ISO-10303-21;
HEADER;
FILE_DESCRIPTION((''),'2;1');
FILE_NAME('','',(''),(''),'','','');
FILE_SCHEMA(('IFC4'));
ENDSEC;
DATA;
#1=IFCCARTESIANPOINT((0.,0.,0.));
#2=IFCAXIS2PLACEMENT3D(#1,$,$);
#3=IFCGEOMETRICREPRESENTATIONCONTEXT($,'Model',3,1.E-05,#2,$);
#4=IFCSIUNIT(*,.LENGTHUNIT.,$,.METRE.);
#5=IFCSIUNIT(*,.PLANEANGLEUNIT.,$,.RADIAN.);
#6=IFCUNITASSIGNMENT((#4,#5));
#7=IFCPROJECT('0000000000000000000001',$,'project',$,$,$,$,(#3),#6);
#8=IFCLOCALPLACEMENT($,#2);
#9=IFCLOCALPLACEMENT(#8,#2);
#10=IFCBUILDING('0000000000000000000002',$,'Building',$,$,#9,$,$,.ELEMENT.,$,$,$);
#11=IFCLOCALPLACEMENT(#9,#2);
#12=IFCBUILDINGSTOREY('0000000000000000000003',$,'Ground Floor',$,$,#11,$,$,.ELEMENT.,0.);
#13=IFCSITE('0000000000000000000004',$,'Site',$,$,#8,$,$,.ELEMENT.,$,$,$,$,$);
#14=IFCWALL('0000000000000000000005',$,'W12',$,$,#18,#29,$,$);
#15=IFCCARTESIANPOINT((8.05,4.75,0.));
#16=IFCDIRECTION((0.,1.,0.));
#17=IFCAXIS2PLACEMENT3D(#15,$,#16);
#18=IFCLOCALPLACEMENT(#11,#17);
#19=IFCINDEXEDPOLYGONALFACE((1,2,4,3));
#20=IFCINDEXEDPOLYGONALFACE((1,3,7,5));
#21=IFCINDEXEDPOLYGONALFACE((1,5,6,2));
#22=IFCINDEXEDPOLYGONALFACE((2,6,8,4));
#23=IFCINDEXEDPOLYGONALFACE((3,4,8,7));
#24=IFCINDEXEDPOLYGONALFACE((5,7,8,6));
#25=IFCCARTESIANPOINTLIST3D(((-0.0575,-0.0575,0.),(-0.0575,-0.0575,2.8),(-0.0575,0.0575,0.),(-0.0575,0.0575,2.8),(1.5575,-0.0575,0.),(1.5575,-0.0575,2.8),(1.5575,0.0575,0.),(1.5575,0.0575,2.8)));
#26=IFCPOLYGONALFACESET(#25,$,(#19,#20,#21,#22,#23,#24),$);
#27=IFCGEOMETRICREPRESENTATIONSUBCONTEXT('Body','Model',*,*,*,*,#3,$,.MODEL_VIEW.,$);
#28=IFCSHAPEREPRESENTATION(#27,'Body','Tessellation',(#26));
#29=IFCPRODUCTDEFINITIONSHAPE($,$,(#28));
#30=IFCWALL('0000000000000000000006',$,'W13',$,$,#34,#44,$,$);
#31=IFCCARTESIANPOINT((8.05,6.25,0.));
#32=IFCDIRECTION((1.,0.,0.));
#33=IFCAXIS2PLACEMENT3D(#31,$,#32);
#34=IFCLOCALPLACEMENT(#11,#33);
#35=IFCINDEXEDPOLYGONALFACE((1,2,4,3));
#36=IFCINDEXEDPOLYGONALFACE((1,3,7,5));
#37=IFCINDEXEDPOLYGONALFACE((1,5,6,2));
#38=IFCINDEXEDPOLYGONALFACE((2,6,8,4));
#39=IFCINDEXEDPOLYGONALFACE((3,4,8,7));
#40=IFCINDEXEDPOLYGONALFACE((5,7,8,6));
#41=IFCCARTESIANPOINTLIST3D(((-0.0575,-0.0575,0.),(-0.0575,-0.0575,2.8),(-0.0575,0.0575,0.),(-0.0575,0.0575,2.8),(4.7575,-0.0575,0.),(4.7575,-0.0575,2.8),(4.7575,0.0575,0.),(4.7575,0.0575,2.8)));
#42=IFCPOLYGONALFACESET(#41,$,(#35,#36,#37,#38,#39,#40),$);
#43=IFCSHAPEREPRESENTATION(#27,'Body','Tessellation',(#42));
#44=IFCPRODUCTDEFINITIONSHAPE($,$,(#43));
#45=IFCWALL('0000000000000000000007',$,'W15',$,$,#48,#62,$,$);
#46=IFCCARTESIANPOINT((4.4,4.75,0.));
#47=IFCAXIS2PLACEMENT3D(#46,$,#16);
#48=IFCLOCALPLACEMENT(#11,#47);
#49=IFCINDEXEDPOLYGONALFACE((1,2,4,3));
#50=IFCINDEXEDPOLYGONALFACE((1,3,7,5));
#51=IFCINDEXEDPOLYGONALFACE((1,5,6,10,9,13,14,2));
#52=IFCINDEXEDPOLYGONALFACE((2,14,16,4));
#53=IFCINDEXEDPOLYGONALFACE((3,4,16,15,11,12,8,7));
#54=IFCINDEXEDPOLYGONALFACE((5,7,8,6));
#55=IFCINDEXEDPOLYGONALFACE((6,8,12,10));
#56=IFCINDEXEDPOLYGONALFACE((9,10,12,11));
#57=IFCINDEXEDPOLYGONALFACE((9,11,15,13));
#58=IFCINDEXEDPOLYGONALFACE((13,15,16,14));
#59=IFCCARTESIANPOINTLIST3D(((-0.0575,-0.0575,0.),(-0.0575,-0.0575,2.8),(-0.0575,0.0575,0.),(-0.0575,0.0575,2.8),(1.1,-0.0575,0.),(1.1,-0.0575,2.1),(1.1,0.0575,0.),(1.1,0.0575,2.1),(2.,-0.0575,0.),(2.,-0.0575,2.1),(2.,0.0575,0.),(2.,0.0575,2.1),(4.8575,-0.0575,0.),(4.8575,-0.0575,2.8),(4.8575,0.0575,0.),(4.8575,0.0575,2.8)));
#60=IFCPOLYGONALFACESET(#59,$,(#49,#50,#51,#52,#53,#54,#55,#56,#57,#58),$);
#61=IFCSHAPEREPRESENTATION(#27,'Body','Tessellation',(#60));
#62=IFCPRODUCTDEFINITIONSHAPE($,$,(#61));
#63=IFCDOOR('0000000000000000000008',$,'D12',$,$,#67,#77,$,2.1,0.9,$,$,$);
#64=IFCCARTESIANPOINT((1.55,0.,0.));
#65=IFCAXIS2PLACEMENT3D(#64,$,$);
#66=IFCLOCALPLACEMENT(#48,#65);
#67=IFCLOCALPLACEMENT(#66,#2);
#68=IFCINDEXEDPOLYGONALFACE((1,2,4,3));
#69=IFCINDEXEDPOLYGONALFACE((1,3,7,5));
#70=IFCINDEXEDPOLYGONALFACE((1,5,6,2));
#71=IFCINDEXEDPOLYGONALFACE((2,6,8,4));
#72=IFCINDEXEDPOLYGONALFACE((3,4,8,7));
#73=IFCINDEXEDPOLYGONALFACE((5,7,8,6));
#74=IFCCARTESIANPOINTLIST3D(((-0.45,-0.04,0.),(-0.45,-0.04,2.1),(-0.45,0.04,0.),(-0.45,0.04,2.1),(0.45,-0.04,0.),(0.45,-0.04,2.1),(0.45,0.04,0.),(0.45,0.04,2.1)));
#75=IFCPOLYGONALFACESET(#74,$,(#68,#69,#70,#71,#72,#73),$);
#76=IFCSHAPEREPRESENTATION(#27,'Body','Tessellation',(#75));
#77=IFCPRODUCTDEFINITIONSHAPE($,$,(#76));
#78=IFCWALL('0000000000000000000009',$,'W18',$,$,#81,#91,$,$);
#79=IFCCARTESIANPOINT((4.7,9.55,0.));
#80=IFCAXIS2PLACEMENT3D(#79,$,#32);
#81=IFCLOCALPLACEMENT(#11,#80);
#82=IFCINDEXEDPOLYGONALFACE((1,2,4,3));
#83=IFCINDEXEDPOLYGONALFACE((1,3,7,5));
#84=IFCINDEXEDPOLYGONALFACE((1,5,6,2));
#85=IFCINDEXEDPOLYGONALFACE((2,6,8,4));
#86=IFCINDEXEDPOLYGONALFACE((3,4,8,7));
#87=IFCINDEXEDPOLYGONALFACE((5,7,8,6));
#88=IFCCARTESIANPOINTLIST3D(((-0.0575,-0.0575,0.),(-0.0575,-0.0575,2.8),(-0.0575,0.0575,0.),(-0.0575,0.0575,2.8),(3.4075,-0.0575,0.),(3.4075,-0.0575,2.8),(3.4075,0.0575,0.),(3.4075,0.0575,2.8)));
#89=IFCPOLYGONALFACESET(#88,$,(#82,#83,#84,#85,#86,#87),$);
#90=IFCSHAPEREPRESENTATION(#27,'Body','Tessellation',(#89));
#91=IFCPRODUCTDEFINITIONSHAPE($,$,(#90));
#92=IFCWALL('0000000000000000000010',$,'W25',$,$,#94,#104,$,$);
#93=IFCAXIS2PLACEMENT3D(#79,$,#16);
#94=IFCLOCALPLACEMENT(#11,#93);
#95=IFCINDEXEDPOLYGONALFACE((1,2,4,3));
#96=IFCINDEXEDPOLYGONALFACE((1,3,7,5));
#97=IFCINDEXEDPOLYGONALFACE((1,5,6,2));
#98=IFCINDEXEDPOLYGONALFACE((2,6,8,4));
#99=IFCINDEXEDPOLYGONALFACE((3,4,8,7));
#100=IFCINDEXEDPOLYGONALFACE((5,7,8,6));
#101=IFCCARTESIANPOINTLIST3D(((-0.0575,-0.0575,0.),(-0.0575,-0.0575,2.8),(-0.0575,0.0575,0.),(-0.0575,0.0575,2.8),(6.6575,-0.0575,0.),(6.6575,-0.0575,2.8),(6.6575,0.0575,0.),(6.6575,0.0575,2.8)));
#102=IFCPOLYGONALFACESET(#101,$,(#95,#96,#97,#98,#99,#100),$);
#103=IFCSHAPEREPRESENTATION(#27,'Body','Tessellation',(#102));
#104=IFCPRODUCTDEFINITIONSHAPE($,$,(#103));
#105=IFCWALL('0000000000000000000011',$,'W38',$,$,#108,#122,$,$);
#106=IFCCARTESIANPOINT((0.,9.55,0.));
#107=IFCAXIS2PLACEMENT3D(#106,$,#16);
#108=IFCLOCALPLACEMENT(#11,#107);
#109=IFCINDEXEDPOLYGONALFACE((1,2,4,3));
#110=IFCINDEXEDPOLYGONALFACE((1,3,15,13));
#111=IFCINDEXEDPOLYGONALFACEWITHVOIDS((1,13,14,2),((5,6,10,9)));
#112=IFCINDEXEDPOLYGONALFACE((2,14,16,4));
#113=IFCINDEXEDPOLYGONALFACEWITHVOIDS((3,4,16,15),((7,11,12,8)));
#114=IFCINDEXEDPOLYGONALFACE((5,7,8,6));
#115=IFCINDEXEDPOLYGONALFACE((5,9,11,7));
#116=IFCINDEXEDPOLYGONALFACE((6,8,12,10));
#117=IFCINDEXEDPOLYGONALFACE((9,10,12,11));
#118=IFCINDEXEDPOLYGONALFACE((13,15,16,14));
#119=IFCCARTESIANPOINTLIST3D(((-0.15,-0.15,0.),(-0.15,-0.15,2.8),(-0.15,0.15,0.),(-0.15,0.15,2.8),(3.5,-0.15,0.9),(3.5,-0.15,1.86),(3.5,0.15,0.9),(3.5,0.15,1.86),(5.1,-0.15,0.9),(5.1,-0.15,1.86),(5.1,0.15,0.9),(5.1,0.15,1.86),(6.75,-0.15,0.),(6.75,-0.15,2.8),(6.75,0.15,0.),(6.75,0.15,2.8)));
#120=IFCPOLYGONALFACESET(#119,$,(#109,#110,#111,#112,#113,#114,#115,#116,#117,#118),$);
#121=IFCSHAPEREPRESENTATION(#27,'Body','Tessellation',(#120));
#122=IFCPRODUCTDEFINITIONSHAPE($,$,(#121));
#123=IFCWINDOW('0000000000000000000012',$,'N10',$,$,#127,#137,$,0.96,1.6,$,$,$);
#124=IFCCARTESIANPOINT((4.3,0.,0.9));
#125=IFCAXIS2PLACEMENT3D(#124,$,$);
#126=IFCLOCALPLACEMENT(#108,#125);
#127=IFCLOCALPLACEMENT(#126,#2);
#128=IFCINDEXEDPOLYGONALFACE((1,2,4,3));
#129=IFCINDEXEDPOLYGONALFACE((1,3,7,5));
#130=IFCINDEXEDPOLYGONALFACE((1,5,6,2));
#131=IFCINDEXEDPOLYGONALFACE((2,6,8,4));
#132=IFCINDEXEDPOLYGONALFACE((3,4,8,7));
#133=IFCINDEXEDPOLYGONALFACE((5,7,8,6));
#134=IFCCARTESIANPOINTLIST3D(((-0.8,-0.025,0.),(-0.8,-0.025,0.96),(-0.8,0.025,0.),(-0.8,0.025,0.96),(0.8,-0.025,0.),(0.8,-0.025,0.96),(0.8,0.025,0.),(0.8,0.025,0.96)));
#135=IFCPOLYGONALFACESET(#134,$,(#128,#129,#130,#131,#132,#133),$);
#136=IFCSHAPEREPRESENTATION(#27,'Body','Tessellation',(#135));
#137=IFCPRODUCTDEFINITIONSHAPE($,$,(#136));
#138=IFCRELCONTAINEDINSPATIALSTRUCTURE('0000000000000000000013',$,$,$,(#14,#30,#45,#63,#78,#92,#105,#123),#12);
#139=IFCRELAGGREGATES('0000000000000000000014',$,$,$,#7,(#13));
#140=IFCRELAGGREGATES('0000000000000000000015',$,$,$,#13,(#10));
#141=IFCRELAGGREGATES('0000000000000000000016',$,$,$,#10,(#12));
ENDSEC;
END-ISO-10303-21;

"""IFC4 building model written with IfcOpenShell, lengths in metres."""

from ifc_helpers import new_model, si_unit, frame, frame_2d, origin, origin_2d, place, context, subcontext, project, spatial, rectangle, extrude, element, fill, save


model = new_model("IFC4")

# Units and contexts
model_context = context("Model", 3, precision=1e-05, world=origin())
body_context = subcontext(model_context, "Body", "Model", "MODEL_VIEW")
ifc_project = project(units=[si_unit("LENGTHUNIT", "METRE"), si_unit("PLANEANGLEUNIT", "RADIAN")], contexts=[model_context])

# Site, building, storey
site_placement = place(None, origin())
site = spatial("IfcSite", under=ifc_project, at=site_placement, Name="Site", CompositionType="ELEMENT")
building_placement = place(site_placement, origin())
building = spatial("IfcBuilding", under=site, at=building_placement, Name="Building", CompositionType="ELEMENT")
storey_placement = place(building_placement, origin())
storey = spatial("IfcBuildingStorey", under=building, at=storey_placement, Name="Ground Floor", CompositionType="ELEMENT", Elevation=0.0)

# Walls
wall_1_placement = place(storey_placement, frame((8.05, 4.75, 0.0), x_axis=(0.0, 1.0, 0.0)))
element("IfcWall", 1, at=wall_1_placement, inside=storey, Name="W12", context=body_context, shape_type="SweptSolid", body=[
    extrude(rectangle(XDim=1.615, YDim=0.115, at=frame_2d((0.75, 0.0))), origin(), (0.0, 0.0, 1.0), 2.8),
])
wall_2_placement = place(storey_placement, frame((8.05, 6.25, 0.0), x_axis=(1.0, 0.0, 0.0)))
element("IfcWall", 2, at=wall_2_placement, inside=storey, Name="W13", context=body_context, shape_type="SweptSolid", body=[
    extrude(rectangle(XDim=4.815, YDim=0.115, at=frame_2d((2.35, 0.0))), origin(), (0.0, 0.0, 1.0), 2.8),
])

# Wall, opening, door
wall_3_placement = place(storey_placement, frame((4.4, 4.75, 0.0), x_axis=(0.0, 1.0, 0.0)))
wall_3 = element("IfcWall", 3, at=wall_3_placement, inside=storey, Name="W15", context=body_context, shape_type="SweptSolid", body=[
    extrude(rectangle(XDim=4.915, YDim=0.115, at=frame_2d((2.4, 0.0))), origin(), (0.0, 0.0, 1.0), 2.8),
])
opening_1_placement = place(wall_3_placement, frame((1.55, 0.0, 0.0)))
opening_1 = element("IfcOpeningElement", 4, at=opening_1_placement, cuts=wall_3, context=body_context, shape_type="SweptSolid", body=[
    extrude(rectangle(XDim=0.9, YDim=0.215, at=origin_2d()), origin(), (0.0, 0.0, 1.0), 2.1),
])
door_1_placement = place(opening_1_placement, origin())
door_1 = element("IfcDoor", 5, at=door_1_placement, inside=storey, Name="D12", OverallHeight=2.1, OverallWidth=0.9, context=body_context, shape_type="SweptSolid", body=[
    extrude(rectangle(XDim=0.9, YDim=0.08, at=origin_2d()), origin(), (0.0, 0.0, 1.0), 2.1),
])
fill(opening_1, door_1)

# Walls
wall_4_placement = place(storey_placement, frame((4.7, 9.55, 0.0), x_axis=(1.0, 0.0, 0.0)))
element("IfcWall", 6, at=wall_4_placement, inside=storey, Name="W18", context=body_context, shape_type="SweptSolid", body=[
    extrude(rectangle(XDim=3.465, YDim=0.115, at=frame_2d((1.675, 0.0))), origin(), (0.0, 0.0, 1.0), 2.8),
])
wall_5_placement = place(storey_placement, frame((4.7, 9.55, 0.0), x_axis=(0.0, 1.0, 0.0)))
element("IfcWall", 7, at=wall_5_placement, inside=storey, Name="W25", context=body_context, shape_type="SweptSolid", body=[
    extrude(rectangle(XDim=6.715, YDim=0.115, at=frame_2d((3.3, 0.0))), origin(), (0.0, 0.0, 1.0), 2.8),
])

# Wall, opening, window
wall_6_placement = place(storey_placement, frame((0.0, 9.55, 0.0), x_axis=(0.0, 1.0, 0.0)))
wall_6 = element("IfcWall", 8, at=wall_6_placement, inside=storey, Name="W38", context=body_context, shape_type="SweptSolid", body=[
    extrude(rectangle(XDim=6.9, YDim=0.3, at=frame_2d((3.3, 0.0))), origin(), (0.0, 0.0, 1.0), 2.8),
])
opening_2_placement = place(wall_6_placement, frame((4.3, 0.0, 0.9)))
opening_2 = element("IfcOpeningElement", 9, at=opening_2_placement, cuts=wall_6, context=body_context, shape_type="SweptSolid", body=[
    extrude(rectangle(XDim=1.6, YDim=0.4, at=origin_2d()), origin(), (0.0, 0.0, 1.0), 0.96),
])
window_1_placement = place(opening_2_placement, origin())
window_1 = element("IfcWindow", 10, at=window_1_placement, inside=storey, Name="N10", OverallHeight=0.96, OverallWidth=1.6, context=body_context, shape_type="SweptSolid", body=[
    extrude(rectangle(XDim=1.6, YDim=0.05, at=origin_2d()), origin(), (0.0, 0.0, 1.0), 0.96),
])
fill(opening_2, window_1)

save(model, "model.ifc")
